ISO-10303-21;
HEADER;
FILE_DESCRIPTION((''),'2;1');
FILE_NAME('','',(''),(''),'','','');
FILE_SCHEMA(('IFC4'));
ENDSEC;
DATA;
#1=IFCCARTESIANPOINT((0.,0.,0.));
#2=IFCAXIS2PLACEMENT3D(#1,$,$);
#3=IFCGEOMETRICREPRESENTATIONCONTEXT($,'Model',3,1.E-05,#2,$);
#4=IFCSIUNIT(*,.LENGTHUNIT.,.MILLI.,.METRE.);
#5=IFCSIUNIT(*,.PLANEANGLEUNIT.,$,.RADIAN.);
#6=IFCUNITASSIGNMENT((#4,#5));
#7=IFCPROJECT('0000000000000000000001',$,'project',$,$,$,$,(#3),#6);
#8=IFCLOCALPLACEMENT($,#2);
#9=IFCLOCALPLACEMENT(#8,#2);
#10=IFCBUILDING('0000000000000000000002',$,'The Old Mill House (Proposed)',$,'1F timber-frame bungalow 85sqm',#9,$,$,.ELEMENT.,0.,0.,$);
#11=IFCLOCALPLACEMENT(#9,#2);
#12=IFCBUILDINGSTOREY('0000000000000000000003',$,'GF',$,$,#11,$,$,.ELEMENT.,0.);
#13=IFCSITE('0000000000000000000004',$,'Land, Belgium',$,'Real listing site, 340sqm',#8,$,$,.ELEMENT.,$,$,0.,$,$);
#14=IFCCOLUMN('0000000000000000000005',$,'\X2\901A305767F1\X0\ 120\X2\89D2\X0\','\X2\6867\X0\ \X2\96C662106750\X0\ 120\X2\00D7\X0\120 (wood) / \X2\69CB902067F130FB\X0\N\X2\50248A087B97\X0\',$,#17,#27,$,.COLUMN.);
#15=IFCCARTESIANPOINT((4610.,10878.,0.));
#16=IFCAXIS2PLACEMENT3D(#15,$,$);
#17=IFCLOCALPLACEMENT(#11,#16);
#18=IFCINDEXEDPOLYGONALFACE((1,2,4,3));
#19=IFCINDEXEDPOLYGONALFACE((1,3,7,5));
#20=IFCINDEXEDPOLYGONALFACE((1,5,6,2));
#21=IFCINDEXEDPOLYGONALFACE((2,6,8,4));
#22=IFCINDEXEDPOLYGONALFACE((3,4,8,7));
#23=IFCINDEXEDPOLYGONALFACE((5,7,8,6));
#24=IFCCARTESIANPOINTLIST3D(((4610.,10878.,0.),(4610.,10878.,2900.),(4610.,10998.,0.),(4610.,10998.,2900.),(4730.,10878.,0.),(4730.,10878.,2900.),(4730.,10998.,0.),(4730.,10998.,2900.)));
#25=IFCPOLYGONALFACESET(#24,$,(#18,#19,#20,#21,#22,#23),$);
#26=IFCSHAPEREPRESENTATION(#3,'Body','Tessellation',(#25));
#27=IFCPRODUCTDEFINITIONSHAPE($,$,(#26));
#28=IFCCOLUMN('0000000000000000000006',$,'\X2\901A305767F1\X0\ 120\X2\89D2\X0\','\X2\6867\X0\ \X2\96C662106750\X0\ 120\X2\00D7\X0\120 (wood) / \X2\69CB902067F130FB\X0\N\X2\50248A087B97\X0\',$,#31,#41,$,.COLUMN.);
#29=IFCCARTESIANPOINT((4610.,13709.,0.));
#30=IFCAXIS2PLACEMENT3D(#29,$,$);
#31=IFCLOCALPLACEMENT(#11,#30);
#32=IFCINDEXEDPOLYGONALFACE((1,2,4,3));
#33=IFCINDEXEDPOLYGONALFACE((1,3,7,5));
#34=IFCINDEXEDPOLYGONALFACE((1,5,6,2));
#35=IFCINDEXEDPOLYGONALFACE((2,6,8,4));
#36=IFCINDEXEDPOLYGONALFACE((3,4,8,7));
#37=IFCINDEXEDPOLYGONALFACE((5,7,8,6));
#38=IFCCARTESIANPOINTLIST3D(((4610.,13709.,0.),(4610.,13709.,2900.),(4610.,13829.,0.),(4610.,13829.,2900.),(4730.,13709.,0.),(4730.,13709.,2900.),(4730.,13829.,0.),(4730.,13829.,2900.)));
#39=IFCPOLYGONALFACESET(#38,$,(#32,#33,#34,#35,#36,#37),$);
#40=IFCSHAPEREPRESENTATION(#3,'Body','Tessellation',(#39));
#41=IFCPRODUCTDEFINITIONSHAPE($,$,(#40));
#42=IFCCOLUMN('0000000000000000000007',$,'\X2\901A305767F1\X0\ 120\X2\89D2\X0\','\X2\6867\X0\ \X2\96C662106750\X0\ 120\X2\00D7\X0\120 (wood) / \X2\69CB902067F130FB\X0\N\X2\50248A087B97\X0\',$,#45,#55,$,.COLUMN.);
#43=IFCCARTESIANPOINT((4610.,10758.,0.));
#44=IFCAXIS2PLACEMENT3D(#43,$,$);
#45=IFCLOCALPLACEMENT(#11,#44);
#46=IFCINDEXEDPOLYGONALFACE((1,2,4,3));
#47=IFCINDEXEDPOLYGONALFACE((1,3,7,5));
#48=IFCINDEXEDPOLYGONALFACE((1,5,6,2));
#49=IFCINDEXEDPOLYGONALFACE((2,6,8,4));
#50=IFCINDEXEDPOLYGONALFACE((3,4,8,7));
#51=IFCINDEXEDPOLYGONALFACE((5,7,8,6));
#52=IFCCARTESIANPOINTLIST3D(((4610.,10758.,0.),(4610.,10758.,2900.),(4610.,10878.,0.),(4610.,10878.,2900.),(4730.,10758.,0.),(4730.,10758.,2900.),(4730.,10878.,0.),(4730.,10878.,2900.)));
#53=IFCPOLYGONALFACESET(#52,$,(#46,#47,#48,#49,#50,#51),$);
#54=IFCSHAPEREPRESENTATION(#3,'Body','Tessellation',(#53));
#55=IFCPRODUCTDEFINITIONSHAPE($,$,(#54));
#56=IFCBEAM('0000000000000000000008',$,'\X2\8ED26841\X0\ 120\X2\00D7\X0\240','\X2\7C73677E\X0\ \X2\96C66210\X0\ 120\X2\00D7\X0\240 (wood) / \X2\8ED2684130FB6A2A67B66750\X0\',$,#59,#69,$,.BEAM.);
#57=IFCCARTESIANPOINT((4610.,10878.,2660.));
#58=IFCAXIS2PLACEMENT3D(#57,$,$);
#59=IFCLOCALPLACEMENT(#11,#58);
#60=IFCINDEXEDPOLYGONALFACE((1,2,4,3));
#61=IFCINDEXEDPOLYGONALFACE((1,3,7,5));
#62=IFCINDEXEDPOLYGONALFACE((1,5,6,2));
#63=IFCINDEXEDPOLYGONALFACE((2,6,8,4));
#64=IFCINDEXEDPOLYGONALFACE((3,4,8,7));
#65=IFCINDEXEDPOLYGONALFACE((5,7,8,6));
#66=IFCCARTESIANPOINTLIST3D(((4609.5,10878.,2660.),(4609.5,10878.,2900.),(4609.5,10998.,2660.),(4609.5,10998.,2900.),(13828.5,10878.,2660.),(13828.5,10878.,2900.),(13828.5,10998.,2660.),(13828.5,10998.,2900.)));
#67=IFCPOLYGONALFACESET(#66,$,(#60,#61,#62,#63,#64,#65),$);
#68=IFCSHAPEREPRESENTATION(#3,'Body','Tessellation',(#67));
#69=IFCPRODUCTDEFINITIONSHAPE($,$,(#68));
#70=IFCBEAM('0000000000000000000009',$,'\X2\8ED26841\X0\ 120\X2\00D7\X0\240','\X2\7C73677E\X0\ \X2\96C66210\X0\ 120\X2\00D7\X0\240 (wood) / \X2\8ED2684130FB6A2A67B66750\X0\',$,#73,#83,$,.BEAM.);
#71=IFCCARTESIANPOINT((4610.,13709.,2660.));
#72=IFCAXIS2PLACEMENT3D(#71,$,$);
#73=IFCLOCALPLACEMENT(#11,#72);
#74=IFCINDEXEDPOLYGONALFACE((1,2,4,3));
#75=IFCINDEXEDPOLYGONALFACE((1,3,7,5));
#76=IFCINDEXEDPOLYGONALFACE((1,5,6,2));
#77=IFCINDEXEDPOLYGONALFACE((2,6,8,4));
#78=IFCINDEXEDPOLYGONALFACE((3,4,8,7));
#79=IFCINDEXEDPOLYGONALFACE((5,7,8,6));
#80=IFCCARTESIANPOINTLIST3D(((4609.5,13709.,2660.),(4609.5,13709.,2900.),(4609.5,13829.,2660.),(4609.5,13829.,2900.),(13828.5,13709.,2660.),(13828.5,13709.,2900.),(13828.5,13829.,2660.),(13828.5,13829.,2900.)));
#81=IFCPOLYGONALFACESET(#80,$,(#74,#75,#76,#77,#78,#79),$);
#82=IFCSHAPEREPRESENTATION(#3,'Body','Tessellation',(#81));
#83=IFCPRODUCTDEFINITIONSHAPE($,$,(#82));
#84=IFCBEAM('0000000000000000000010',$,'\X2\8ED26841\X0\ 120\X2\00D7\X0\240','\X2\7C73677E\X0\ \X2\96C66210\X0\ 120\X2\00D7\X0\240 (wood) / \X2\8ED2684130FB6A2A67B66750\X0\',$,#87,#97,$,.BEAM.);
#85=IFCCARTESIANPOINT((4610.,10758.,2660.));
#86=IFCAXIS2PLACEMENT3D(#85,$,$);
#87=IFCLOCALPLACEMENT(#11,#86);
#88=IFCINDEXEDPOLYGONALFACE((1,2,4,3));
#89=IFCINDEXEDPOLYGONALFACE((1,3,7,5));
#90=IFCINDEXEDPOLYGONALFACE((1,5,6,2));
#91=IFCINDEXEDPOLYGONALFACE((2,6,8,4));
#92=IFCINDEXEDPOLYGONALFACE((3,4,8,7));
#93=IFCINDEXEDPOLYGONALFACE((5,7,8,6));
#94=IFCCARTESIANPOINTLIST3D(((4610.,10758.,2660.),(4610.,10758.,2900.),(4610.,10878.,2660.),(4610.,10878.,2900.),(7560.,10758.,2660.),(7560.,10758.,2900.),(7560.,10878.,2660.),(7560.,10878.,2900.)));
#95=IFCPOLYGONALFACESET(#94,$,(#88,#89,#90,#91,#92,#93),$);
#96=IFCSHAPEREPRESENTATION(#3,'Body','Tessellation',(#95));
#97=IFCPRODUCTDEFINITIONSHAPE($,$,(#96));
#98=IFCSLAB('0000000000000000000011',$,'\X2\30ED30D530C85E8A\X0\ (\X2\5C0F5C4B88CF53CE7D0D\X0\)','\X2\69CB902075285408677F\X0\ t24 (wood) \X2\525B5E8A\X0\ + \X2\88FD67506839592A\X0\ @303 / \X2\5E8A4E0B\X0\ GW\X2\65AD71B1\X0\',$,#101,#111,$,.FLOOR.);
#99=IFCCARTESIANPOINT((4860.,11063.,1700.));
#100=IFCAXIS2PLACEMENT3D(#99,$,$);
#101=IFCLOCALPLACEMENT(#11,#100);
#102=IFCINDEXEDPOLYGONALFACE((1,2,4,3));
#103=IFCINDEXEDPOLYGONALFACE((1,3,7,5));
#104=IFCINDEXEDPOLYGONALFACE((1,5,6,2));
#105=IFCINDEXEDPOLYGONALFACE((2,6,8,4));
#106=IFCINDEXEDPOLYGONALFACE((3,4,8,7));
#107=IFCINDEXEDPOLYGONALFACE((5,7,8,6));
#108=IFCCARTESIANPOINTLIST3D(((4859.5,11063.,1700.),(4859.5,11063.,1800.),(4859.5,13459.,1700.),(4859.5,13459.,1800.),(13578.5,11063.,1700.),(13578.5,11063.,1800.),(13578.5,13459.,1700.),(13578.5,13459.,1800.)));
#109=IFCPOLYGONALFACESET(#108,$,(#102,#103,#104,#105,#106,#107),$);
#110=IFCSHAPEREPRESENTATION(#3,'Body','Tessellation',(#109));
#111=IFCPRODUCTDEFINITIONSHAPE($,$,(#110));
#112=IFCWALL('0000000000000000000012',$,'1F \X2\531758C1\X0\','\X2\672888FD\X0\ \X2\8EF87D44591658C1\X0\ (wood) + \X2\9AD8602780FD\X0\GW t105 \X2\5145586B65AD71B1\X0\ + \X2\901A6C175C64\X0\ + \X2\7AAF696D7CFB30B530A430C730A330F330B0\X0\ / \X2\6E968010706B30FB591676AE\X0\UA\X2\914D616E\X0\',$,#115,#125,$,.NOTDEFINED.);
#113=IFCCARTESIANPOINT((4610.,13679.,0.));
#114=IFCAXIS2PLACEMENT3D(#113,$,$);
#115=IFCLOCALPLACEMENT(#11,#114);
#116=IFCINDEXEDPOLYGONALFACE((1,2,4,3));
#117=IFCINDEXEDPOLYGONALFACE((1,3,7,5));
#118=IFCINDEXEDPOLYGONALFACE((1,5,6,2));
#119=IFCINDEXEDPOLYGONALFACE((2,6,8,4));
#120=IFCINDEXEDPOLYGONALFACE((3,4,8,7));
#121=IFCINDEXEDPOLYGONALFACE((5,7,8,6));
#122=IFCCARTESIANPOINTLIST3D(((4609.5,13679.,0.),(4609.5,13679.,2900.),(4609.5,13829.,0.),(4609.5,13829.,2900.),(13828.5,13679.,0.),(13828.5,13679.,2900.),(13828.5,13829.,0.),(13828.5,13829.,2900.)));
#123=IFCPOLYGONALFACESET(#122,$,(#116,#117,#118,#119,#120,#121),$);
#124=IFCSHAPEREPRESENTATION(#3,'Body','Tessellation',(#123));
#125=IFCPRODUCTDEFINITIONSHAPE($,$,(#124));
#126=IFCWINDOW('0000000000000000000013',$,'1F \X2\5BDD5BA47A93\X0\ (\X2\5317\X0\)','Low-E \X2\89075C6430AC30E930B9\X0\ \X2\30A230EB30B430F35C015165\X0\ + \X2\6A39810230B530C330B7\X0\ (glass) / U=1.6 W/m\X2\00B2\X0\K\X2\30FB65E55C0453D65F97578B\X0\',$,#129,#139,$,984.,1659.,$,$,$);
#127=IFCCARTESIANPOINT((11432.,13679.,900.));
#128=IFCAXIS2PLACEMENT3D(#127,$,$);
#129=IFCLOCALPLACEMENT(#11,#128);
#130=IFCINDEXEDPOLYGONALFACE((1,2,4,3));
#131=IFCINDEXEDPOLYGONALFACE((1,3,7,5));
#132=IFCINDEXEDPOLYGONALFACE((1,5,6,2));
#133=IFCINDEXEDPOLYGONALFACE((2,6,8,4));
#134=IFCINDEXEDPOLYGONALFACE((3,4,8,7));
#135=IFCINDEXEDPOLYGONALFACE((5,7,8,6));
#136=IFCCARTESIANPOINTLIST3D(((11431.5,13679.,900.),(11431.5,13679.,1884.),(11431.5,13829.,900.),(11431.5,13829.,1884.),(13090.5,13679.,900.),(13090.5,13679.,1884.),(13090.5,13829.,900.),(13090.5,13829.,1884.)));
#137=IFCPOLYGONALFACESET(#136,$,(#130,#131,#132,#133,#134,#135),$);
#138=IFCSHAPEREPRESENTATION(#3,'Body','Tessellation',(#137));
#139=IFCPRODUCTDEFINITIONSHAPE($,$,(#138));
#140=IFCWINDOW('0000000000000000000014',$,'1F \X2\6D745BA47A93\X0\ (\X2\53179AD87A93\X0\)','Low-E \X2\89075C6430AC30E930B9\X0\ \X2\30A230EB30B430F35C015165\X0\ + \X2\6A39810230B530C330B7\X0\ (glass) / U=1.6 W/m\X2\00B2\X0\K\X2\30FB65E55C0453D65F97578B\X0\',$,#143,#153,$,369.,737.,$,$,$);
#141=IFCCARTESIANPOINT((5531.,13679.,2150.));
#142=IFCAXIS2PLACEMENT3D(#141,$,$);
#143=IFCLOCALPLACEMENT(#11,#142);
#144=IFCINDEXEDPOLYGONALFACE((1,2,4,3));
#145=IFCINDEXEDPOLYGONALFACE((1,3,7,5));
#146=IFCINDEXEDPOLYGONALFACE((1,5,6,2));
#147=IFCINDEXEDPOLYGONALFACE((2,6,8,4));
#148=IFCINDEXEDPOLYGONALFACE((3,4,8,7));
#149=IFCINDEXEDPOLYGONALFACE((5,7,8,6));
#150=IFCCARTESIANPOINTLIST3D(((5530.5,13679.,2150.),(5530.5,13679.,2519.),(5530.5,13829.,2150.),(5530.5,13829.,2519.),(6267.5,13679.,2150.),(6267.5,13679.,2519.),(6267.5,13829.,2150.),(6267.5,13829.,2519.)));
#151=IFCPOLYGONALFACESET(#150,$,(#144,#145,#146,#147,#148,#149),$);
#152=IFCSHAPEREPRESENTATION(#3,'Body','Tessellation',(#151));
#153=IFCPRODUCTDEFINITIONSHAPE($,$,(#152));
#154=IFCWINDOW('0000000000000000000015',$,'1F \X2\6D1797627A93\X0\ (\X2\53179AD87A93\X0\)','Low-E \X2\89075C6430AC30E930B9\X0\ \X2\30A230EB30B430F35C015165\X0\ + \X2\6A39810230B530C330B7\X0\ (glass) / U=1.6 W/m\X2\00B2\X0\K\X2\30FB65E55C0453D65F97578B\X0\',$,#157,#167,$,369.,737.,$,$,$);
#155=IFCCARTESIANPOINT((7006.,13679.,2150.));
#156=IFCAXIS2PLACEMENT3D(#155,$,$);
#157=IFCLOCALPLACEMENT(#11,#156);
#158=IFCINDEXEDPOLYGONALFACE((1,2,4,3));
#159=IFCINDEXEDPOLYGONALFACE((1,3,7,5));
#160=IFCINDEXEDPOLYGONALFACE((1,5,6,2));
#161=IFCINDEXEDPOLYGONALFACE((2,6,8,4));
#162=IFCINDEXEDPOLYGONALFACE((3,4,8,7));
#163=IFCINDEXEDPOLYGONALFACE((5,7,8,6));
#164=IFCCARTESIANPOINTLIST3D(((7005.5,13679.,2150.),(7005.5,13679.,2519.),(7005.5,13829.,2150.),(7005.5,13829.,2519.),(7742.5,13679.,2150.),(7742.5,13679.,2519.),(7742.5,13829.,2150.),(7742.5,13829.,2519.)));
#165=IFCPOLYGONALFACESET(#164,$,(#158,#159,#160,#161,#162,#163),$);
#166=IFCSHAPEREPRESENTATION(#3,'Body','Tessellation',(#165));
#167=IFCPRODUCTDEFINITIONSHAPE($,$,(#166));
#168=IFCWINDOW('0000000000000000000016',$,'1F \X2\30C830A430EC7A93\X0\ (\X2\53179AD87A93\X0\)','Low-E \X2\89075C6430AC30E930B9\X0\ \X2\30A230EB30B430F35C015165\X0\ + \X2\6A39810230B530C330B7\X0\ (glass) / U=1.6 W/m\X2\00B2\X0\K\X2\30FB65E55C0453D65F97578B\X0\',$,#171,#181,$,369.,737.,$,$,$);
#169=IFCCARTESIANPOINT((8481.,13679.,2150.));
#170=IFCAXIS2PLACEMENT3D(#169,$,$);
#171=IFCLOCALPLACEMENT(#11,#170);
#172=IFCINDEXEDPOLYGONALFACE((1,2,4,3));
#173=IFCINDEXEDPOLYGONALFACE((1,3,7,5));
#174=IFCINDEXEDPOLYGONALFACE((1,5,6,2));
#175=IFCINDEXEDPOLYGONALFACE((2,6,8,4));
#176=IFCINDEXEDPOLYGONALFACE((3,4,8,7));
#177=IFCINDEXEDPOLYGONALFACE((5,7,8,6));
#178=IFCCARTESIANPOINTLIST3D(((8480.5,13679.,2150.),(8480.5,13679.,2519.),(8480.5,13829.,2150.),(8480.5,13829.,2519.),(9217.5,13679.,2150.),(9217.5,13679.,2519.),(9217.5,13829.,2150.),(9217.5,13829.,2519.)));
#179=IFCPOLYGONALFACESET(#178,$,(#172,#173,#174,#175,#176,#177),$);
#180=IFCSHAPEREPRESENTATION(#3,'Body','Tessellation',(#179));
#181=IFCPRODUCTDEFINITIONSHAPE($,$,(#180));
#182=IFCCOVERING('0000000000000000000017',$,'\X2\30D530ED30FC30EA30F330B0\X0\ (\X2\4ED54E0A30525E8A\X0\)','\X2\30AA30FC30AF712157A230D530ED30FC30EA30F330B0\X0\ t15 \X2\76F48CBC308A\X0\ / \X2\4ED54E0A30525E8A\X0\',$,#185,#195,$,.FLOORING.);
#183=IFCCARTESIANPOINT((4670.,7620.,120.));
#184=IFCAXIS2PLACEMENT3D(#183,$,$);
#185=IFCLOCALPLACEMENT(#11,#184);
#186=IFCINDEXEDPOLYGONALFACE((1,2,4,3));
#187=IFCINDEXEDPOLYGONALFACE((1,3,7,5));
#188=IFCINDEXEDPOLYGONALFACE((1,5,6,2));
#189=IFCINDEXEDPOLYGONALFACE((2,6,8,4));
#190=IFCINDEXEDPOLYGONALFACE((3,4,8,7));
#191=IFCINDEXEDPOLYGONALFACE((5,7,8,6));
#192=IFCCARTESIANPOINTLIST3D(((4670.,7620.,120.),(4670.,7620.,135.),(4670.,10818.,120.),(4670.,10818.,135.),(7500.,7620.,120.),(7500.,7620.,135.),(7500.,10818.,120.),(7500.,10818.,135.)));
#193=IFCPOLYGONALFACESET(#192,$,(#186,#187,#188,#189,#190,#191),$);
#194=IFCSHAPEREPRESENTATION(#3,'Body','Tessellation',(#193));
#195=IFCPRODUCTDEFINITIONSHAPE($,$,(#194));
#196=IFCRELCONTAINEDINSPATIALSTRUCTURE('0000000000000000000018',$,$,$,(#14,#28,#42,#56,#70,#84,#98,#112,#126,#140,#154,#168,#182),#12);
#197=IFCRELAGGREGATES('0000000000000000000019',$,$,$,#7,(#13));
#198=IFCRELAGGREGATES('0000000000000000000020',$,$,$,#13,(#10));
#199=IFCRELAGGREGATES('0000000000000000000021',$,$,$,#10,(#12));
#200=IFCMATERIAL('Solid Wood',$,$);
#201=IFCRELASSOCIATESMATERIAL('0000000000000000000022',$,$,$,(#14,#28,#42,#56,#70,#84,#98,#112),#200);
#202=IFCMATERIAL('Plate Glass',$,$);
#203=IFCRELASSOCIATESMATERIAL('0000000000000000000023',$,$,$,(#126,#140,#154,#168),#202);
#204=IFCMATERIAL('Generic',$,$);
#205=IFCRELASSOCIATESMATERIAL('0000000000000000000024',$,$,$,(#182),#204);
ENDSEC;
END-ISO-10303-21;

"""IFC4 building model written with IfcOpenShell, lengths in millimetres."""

from ifc_helpers import new_model, si_unit, frame, frame_2d, origin, place, context, project, spatial, rectangle, extrude, material, element, fill, save


model = new_model("IFC4")

# Units and contexts
model_context = context("Model", 3, precision=1e-05, world=origin())
ifc_project = project(units=[si_unit("LENGTHUNIT", "METRE", prefix="MILLI"), si_unit("PLANEANGLEUNIT", "RADIAN")], contexts=[model_context])

# Site, building, storey
site_placement = place(None, origin())
site = spatial("IfcSite", under=ifc_project, at=site_placement, Name="Land, Belgium", ObjectType="Real listing site, 340sqm", CompositionType="ELEMENT", RefElevation=0.0)
building_placement = place(site_placement, origin())
building = spatial("IfcBuilding", under=site, at=building_placement, Name="The Old Mill House (Proposed)", ObjectType="1F timber-frame bungalow 85sqm", CompositionType="ELEMENT", ElevationOfRefHeight=0.0, ElevationOfTerrain=0.0)
storey_placement = place(building_placement, origin())
storey = spatial("IfcBuildingStorey", under=building, at=storey_placement, Name="GF", CompositionType="ELEMENT", Elevation=0.0)

# Columns
ifc_material_1 = material(Name="Solid Wood")
column_1_placement = place(storey_placement, frame((4610.0, 10878.0, 0.0)))
element("IfcColumn", 1, at=column_1_placement, inside=storey, material=ifc_material_1, Name="通し柱 120角", Description="桧 集成材 120×120 (wood) / 構造柱・N値計算", PredefinedType="COLUMN", context=model_context, shape_type="SweptSolid", body=[
    extrude(rectangle(XDim=120.0, YDim=120.0, at=frame_2d((60.0, 60.0))), frame((4610.0, 10878.0, 0.0)), (0.0, 0.0, 1.0), 2900.0),
])
column_2_placement = place(storey_placement, frame((4610.0, 13709.0, 0.0)))
element("IfcColumn", 2, at=column_2_placement, inside=storey, material=ifc_material_1, Name="通し柱 120角", Description="桧 集成材 120×120 (wood) / 構造柱・N値計算", PredefinedType="COLUMN", context=model_context, shape_type="SweptSolid", body=[
    extrude(rectangle(XDim=120.0, YDim=120.0, at=frame_2d((60.0, 60.0))), frame((4610.0, 13709.0, 0.0)), (0.0, 0.0, 1.0), 2900.0),
])
column_3_placement = place(storey_placement, frame((4610.0, 10758.0, 0.0)))
element("IfcColumn", 3, at=column_3_placement, inside=storey, material=ifc_material_1, Name="通し柱 120角", Description="桧 集成材 120×120 (wood) / 構造柱・N値計算", PredefinedType="COLUMN", context=model_context, shape_type="SweptSolid", body=[
    extrude(rectangle(XDim=120.0, YDim=120.0, at=frame_2d((60.0, 60.0))), frame((4610.0, 10758.0, 0.0)), (0.0, 0.0, 1.0), 2900.0),
])

# Beams
beam_1_placement = place(storey_placement, frame((4610.0, 10878.0, 2660.0)))
element("IfcBeam", 4, at=beam_1_placement, inside=storey, material=ifc_material_1, Name="軒桁 120×240", Description="米松 集成 120×240 (wood) / 軒桁・横架材", PredefinedType="BEAM", context=model_context, shape_type="SweptSolid", body=[
    extrude(rectangle(XDim=9219.0, YDim=120.0, at=frame_2d((4609.0, 60.0))), frame((4610.0, 10878.0, 2660.0)), (0.0, 0.0, 1.0), 240.0),
])
beam_2_placement = place(storey_placement, frame((4610.0, 13709.0, 2660.0)))
element("IfcBeam", 5, at=beam_2_placement, inside=storey, material=ifc_material_1, Name="軒桁 120×240", Description="米松 集成 120×240 (wood) / 軒桁・横架材", PredefinedType="BEAM", context=model_context, shape_type="SweptSolid", body=[
    extrude(rectangle(XDim=9219.0, YDim=120.0, at=frame_2d((4609.0, 60.0))), frame((4610.0, 13709.0, 2660.0)), (0.0, 0.0, 1.0), 240.0),
])
beam_3_placement = place(storey_placement, frame((4610.0, 10758.0, 2660.0)))
element("IfcBeam", 6, at=beam_3_placement, inside=storey, material=ifc_material_1, Name="軒桁 120×240", Description="米松 集成 120×240 (wood) / 軒桁・横架材", PredefinedType="BEAM", context=model_context, shape_type="SweptSolid", body=[
    extrude(rectangle(XDim=2950.0, YDim=120.0, at=frame_2d((1475.0, 60.0))), frame((4610.0, 10758.0, 2660.0)), (0.0, 0.0, 1.0), 240.0),
])

# Slab
slab_1_placement = place(storey_placement, frame((4860.0, 11063.0, 1700.0)))
element("IfcSlab", 7, at=slab_1_placement, inside=storey, material=ifc_material_1, Name="ロフト床 (小屋裏収納)", Description="構造用合板 t24 (wood) 剛床 + 製材根太 @303 / 床下 GW断熱", PredefinedType="FLOOR", context=model_context, shape_type="SweptSolid", body=[
    extrude(rectangle(XDim=8719.0, YDim=2396.0, at=frame_2d((4359.0, 1198.0))), frame((4860.0, 11063.0, 1700.0)), (0.0, 0.0, 1.0), 100.0),
])

# Wall, openings, windows
wall_1_placement = place(storey_placement, frame((4610.0, 13679.0, 0.0)))
wall_1 = element("IfcWall", 8, at=wall_1_placement, inside=storey, material=ifc_material_1, Name="1F 北壁", Description="木製 軸組外壁 (wood) + 高性能GW t105 充填断熱 + 通気層 + 窯業系サイディング / 準耐火・外皮UA配慮", PredefinedType="NOTDEFINED", context=model_context, shape_type="SweptSolid", body=[
    extrude(rectangle(XDim=9219.0, YDim=150.0, at=frame_2d((4609.0, 75.0))), frame((4610.0, 13679.0, 0.0)), (0.0, 0.0, 1.0), 2900.0),
])
opening_1_placement = place(storey_placement, frame((11432.0, 13679.0, 900.0)))
opening_1 = element("IfcOpeningElement", 9, at=opening_1_placement, cuts=wall_1, PredefinedType="NOTDEFINED", context=model_context, shape_type="SweptSolid", body=[
    extrude(rectangle(XDim=1659.0, YDim=150.0, at=frame_2d((829.0, 75.0))), frame((11432.0, 13679.0, 900.0)), (0.0, 0.0, 1.0), 984.0),
])
opening_2_placement = place(storey_placement, frame((5531.0, 13679.0, 2150.0)))
opening_2 = element("IfcOpeningElement", 10, at=opening_2_placement, cuts=wall_1, PredefinedType="NOTDEFINED", context=model_context, shape_type="SweptSolid", body=[
    extrude(rectangle(XDim=737.0, YDim=150.0, at=frame_2d((368.0, 75.0))), frame((5531.0, 13679.0, 2150.0)), (0.0, 0.0, 1.0), 369.0),
])
opening_3_placement = place(storey_placement, frame((7006.0, 13679.0, 2150.0)))
opening_3 = element("IfcOpeningElement", 11, at=opening_3_placement, cuts=wall_1, PredefinedType="NOTDEFINED", context=model_context, shape_type="SweptSolid", body=[
    extrude(rectangle(XDim=737.0, YDim=150.0, at=frame_2d((368.0, 75.0))), frame((7006.0, 13679.0, 2150.0)), (0.0, 0.0, 1.0), 369.0),
])
opening_4_placement = place(storey_placement, frame((8481.0, 13679.0, 2150.0)))
opening_4 = element("IfcOpeningElement", 12, at=opening_4_placement, cuts=wall_1, PredefinedType="NOTDEFINED", context=model_context, shape_type="SweptSolid", body=[
    extrude(rectangle(XDim=737.0, YDim=150.0, at=frame_2d((368.0, 75.0))), frame((8481.0, 13679.0, 2150.0)), (0.0, 0.0, 1.0), 369.0),
])
ifc_material_2 = material(Name="Plate Glass")
window_1_placement = place(storey_placement, frame((11432.0, 13679.0, 900.0)))
window_1 = element("IfcWindow", 13, at=window_1_placement, inside=storey, material=ifc_material_2, Name="1F 寝室窓 (北)", Description="Low-E 複層ガラス アルゴン封入 + 樹脂サッシ (glass) / U=1.6 W/m²K・日射取得型", OverallHeight=984.0, OverallWidth=1659.0, context=model_context, shape_type="SweptSolid", body=[
    extrude(rectangle(XDim=1659.0, YDim=150.0, at=frame_2d((829.0, 75.0))), frame((11432.0, 13679.0, 900.0)), (0.0, 0.0, 1.0), 984.0),
])
fill(opening_1, window_1)
window_2_placement = place(storey_placement, frame((5531.0, 13679.0, 2150.0)))
window_2 = element("IfcWindow", 14, at=window_2_placement, inside=storey, material=ifc_material_2, Name="1F 浴室窓 (北高窓)", Description="Low-E 複層ガラス アルゴン封入 + 樹脂サッシ (glass) / U=1.6 W/m²K・日射取得型", OverallHeight=369.0, OverallWidth=737.0, context=model_context, shape_type="SweptSolid", body=[
    extrude(rectangle(XDim=737.0, YDim=150.0, at=frame_2d((368.0, 75.0))), frame((5531.0, 13679.0, 2150.0)), (0.0, 0.0, 1.0), 369.0),
])
fill(opening_2, window_2)
window_3_placement = place(storey_placement, frame((7006.0, 13679.0, 2150.0)))
window_3 = element("IfcWindow", 15, at=window_3_placement, inside=storey, material=ifc_material_2, Name="1F 洗面窓 (北高窓)", Description="Low-E 複層ガラス アルゴン封入 + 樹脂サッシ (glass) / U=1.6 W/m²K・日射取得型", OverallHeight=369.0, OverallWidth=737.0, context=model_context, shape_type="SweptSolid", body=[
    extrude(rectangle(XDim=737.0, YDim=150.0, at=frame_2d((368.0, 75.0))), frame((7006.0, 13679.0, 2150.0)), (0.0, 0.0, 1.0), 369.0),
])
fill(opening_3, window_3)
window_4_placement = place(storey_placement, frame((8481.0, 13679.0, 2150.0)))
window_4 = element("IfcWindow", 16, at=window_4_placement, inside=storey, material=ifc_material_2, Name="1F トイレ窓 (北高窓)", Description="Low-E 複層ガラス アルゴン封入 + 樹脂サッシ (glass) / U=1.6 W/m²K・日射取得型", OverallHeight=369.0, OverallWidth=737.0, context=model_context, shape_type="SweptSolid", body=[
    extrude(rectangle(XDim=737.0, YDim=150.0, at=frame_2d((368.0, 75.0))), frame((8481.0, 13679.0, 2150.0)), (0.0, 0.0, 1.0), 369.0),
])
fill(opening_4, window_4)

# Covering
ifc_material_3 = material(Name="Generic")
covering_1_placement = place(storey_placement, frame((4670.0, 7620.0, 120.0)))
element("IfcCovering", 17, at=covering_1_placement, inside=storey, material=ifc_material_3, Name="フローリング (仕上げ床)", Description="オーク無垢フローリング t15 直貼り / 仕上げ床", PredefinedType="FLOORING", context=model_context, shape_type="SweptSolid", body=[
    extrude(rectangle(XDim=2830.0, YDim=3198.0, at=frame_2d((1415.0, 1599.0))), frame((4670.0, 7620.0, 120.0)), (0.0, 0.0, 1.0), 15.0),
])

save(model, "model.ifc")
